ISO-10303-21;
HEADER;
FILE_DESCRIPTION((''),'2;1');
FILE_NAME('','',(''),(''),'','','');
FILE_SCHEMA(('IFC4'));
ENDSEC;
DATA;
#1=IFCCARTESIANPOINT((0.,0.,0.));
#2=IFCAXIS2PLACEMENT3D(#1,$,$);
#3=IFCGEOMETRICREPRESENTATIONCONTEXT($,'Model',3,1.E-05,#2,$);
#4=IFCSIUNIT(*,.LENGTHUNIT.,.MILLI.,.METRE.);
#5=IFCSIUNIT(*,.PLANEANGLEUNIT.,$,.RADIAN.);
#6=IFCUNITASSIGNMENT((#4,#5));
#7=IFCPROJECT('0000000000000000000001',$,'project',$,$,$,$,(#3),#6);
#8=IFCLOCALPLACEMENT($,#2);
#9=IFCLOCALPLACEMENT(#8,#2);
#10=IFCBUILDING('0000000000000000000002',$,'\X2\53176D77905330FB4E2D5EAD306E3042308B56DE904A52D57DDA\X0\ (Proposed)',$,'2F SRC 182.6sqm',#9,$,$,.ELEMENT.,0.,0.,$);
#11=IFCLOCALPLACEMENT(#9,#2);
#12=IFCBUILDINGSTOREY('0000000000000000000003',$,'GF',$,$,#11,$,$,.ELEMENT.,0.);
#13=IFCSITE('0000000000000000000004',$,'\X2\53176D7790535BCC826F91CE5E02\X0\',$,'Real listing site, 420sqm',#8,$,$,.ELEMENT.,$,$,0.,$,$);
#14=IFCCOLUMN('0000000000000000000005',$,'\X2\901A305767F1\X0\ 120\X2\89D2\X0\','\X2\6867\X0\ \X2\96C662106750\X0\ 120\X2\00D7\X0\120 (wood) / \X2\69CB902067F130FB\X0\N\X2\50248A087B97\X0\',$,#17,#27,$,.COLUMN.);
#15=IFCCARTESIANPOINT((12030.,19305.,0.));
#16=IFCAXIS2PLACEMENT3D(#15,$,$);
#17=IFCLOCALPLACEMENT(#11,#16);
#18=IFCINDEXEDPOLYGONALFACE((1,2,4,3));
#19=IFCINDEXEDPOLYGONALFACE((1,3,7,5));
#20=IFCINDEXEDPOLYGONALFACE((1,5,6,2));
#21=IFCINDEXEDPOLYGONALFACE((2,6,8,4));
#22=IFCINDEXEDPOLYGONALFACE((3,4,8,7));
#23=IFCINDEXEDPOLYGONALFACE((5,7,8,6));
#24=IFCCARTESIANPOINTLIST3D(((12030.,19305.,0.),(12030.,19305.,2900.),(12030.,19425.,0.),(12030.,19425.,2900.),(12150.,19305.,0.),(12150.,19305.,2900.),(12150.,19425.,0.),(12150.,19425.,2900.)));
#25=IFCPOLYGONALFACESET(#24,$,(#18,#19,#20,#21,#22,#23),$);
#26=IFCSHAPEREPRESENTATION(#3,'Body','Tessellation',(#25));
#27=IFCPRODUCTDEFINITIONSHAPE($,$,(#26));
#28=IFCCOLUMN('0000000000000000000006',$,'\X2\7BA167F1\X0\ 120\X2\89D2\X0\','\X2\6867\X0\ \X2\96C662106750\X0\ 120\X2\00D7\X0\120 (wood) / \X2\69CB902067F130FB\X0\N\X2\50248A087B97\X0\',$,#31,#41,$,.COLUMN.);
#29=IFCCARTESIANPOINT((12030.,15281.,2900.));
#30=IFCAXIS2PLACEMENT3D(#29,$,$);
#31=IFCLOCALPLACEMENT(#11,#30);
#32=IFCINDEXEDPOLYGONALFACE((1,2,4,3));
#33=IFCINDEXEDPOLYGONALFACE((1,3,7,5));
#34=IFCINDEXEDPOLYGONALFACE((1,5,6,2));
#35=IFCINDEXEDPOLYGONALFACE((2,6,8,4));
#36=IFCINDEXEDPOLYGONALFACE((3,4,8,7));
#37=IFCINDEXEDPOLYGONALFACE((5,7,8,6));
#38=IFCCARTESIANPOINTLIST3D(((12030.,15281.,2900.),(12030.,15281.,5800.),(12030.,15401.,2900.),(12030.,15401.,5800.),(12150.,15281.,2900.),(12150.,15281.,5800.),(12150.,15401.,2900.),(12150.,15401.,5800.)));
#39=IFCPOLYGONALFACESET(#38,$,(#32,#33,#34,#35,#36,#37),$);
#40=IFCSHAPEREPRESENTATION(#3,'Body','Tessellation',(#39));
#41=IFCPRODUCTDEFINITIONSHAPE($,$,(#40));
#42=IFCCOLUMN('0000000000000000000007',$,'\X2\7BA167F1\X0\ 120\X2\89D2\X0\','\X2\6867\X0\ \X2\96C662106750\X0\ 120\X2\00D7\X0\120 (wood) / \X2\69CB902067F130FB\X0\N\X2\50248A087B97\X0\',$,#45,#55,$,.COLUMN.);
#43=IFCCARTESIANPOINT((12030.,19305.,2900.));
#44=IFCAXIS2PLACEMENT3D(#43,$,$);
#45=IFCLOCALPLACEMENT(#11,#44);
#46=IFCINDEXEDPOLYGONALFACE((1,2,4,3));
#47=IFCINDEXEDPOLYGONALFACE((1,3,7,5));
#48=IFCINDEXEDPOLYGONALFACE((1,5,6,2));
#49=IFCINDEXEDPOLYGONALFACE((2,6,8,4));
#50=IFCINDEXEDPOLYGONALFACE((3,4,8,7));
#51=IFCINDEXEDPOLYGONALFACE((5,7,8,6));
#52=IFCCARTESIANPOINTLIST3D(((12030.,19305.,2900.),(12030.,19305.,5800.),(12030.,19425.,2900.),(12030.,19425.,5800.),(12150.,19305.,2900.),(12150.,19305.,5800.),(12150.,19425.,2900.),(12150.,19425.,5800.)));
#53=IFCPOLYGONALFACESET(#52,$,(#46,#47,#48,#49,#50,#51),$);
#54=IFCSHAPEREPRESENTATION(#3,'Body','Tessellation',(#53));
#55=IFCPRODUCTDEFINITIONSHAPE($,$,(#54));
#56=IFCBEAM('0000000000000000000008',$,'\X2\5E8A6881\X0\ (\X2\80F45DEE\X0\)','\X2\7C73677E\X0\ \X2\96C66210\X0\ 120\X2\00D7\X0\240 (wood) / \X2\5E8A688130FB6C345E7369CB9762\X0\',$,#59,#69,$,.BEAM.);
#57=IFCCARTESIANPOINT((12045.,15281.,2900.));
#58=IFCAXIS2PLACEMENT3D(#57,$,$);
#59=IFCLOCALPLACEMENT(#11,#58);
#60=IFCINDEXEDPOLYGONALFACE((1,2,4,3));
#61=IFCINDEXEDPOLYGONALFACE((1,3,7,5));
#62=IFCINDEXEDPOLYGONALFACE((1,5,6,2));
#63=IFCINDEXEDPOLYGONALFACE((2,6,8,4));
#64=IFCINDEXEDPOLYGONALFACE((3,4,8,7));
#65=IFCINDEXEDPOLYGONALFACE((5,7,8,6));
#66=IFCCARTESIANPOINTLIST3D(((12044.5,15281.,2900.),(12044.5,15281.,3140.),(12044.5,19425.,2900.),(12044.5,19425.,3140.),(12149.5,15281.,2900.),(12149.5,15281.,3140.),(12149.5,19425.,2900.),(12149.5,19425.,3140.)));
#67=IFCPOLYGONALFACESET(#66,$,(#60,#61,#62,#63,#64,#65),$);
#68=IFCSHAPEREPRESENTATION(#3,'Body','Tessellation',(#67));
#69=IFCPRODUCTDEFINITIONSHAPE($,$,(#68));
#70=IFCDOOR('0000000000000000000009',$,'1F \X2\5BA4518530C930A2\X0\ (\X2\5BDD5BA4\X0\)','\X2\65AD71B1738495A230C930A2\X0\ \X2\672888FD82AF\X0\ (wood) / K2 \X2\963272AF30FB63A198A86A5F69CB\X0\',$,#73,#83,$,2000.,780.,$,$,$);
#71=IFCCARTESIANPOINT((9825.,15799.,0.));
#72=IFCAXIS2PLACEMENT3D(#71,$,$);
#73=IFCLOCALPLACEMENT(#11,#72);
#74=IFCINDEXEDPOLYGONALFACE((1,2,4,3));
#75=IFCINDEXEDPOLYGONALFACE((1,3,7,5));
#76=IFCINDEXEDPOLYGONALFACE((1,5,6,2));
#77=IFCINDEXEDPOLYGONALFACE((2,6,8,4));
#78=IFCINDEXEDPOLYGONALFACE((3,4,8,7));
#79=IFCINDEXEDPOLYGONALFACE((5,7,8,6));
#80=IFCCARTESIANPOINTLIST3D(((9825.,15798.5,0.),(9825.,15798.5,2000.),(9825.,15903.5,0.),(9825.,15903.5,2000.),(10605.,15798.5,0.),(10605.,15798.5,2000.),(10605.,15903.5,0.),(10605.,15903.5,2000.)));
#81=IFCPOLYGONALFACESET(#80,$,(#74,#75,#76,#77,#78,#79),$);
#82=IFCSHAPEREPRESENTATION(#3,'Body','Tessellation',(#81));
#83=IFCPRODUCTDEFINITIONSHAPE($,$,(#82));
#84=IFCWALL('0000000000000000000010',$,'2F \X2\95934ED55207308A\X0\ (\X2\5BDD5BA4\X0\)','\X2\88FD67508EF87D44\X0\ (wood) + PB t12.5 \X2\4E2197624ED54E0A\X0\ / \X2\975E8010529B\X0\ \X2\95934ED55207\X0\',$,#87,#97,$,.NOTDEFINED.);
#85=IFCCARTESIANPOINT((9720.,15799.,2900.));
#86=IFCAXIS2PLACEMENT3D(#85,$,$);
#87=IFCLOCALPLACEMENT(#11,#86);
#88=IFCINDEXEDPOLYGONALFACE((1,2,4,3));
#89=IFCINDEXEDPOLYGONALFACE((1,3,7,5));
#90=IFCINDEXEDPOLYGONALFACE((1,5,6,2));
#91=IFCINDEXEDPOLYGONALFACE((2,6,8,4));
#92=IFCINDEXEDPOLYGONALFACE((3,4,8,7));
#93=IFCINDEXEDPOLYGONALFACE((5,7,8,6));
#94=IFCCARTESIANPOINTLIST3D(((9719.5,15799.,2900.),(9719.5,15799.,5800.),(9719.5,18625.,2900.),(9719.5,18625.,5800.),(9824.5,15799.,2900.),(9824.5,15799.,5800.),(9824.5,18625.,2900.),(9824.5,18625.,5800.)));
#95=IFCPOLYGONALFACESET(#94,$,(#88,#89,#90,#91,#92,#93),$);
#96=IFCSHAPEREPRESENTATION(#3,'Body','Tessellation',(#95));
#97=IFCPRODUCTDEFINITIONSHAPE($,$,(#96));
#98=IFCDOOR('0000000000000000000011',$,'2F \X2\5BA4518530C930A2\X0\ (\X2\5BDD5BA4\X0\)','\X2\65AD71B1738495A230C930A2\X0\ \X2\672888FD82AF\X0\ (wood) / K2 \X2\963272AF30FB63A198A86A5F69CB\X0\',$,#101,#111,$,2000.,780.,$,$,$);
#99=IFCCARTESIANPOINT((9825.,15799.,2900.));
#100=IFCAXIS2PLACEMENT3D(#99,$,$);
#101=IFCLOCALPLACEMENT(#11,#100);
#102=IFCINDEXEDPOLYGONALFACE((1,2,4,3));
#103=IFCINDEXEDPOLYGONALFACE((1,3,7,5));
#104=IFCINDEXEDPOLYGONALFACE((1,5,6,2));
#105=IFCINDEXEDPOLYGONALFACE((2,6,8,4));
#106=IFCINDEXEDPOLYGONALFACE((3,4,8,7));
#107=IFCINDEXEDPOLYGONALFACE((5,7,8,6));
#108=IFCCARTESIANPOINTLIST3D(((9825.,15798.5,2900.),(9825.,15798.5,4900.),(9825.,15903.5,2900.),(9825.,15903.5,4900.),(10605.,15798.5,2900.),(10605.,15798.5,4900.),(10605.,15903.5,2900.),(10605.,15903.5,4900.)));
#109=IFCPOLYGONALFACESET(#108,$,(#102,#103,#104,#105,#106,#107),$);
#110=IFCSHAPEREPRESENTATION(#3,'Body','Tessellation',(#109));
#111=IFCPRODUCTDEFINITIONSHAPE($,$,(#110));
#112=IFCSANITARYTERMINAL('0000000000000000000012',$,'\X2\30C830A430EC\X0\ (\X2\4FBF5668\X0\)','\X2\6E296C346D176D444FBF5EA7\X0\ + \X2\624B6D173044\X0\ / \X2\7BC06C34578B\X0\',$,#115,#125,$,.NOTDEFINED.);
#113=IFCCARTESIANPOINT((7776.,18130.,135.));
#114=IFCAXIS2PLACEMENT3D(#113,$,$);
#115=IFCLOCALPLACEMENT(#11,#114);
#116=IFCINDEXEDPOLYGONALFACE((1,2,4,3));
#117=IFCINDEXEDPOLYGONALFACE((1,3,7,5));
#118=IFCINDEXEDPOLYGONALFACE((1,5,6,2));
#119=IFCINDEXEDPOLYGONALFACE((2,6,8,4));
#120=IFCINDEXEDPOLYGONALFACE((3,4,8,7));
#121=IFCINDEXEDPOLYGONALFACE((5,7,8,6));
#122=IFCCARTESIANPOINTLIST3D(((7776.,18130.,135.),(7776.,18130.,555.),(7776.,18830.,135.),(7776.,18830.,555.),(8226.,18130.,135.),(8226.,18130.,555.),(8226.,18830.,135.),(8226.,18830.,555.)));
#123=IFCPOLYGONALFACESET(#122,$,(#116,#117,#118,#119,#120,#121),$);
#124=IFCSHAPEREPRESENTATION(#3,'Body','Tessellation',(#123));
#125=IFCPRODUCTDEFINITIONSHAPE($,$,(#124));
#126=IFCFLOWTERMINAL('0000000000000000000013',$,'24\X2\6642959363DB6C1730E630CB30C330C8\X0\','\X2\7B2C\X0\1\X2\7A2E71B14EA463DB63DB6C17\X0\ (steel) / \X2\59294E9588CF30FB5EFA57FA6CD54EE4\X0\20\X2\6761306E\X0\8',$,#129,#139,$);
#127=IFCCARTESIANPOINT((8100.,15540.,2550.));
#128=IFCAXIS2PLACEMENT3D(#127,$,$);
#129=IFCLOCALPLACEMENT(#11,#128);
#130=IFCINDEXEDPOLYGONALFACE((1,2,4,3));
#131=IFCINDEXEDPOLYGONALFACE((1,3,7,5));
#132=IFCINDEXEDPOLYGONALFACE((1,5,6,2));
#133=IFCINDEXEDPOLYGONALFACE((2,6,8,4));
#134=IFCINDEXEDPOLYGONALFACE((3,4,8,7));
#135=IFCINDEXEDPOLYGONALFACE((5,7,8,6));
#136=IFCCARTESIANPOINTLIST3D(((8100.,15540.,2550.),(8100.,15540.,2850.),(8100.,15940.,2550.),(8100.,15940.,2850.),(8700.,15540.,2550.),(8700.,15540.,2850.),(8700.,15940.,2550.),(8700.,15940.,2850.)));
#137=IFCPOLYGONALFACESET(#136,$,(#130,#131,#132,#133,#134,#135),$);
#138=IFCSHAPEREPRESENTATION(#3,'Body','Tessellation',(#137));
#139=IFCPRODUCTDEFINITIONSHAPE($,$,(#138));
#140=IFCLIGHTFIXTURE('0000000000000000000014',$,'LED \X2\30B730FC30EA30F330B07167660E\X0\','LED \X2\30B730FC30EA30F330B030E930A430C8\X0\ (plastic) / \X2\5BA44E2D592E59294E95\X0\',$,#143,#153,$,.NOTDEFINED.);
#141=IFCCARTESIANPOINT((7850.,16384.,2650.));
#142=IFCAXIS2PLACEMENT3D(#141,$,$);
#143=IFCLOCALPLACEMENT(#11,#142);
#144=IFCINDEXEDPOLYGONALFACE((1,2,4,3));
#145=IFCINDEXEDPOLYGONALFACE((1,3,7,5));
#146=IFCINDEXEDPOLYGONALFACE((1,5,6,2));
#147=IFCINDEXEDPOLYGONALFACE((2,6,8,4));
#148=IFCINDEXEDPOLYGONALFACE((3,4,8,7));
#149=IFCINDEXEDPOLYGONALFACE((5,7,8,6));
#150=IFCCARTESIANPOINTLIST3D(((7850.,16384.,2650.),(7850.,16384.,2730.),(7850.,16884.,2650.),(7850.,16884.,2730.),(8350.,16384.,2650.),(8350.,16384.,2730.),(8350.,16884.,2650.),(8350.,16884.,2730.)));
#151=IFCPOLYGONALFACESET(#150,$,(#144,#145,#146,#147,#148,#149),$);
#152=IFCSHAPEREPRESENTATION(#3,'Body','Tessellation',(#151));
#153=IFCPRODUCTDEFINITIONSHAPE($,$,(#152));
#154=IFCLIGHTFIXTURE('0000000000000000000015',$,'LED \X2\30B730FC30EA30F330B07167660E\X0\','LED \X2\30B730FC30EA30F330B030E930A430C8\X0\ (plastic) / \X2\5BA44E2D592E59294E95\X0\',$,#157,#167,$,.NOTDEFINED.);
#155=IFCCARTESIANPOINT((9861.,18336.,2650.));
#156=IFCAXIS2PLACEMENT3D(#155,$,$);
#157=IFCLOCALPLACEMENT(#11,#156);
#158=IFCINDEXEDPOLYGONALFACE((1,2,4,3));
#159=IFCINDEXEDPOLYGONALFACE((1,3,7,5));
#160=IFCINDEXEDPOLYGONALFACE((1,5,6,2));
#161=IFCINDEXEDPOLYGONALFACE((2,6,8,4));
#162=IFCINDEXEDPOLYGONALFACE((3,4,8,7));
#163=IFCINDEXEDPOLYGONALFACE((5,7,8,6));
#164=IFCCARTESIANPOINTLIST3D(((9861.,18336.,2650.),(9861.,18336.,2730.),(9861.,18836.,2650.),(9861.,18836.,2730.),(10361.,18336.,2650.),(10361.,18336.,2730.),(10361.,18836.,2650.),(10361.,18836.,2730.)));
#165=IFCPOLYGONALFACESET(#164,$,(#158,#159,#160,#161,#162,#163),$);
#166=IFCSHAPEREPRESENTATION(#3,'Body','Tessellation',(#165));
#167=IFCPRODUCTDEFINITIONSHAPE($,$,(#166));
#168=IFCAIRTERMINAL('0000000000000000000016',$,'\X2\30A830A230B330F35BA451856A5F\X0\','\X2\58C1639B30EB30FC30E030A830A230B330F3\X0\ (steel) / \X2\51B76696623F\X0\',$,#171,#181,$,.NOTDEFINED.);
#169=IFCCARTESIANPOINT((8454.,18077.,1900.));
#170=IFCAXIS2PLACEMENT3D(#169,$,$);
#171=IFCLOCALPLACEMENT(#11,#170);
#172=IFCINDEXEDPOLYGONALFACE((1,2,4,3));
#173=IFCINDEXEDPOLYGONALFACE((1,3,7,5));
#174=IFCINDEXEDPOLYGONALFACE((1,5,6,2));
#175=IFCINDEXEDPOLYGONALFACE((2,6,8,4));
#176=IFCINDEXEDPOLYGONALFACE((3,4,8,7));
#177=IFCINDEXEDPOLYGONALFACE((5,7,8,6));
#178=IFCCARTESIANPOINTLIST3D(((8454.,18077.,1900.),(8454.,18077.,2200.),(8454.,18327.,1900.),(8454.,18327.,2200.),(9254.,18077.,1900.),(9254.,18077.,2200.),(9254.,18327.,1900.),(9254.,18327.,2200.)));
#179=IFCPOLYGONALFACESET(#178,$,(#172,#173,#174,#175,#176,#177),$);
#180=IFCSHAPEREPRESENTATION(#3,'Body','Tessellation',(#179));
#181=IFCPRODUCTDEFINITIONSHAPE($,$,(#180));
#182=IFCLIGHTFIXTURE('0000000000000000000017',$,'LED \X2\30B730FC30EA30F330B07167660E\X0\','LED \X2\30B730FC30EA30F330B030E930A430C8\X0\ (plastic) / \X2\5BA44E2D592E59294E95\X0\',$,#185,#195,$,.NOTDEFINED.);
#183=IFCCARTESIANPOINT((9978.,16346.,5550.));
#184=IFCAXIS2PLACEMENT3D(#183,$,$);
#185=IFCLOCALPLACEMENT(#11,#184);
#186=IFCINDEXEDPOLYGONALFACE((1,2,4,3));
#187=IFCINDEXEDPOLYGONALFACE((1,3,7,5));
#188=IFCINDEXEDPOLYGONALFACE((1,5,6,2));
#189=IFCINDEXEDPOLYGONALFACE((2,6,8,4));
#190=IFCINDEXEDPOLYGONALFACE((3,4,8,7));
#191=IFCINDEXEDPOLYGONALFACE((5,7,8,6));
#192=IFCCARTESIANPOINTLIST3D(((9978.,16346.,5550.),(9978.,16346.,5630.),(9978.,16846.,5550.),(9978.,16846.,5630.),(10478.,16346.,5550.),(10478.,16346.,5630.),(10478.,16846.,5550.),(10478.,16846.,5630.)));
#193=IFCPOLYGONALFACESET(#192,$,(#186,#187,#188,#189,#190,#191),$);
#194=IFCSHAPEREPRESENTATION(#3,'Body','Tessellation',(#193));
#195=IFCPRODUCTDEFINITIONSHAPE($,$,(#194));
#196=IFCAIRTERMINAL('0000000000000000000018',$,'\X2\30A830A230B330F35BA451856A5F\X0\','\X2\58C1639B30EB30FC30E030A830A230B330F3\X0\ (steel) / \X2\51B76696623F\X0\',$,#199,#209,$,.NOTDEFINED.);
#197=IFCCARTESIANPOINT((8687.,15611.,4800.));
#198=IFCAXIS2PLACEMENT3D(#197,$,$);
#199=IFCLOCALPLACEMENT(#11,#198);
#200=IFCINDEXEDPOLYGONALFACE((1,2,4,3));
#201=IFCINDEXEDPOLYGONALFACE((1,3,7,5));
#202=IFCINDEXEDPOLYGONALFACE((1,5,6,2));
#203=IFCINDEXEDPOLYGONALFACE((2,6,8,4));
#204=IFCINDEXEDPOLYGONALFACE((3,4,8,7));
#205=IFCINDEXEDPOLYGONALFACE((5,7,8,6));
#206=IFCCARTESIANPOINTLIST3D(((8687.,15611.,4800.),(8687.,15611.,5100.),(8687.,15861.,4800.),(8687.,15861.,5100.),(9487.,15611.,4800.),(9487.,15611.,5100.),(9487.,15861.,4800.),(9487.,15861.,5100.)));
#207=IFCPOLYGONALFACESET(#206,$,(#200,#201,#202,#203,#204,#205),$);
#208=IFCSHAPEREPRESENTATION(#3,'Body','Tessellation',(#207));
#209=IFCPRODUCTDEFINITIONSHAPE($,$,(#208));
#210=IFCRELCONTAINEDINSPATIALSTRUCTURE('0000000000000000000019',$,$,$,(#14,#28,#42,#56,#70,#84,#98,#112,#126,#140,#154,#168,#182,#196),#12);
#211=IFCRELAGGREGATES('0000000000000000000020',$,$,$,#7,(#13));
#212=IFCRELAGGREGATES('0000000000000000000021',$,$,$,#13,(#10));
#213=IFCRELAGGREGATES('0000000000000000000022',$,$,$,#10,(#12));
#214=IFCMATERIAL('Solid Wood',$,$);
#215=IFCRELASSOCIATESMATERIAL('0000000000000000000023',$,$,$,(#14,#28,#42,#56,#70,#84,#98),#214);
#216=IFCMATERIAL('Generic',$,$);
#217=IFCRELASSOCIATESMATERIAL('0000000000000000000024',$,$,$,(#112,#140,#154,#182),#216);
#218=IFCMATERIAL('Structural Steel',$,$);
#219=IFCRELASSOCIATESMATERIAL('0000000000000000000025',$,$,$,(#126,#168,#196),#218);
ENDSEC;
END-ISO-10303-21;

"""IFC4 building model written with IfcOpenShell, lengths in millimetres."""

from ifc_helpers import new_model, si_unit, frame, frame_2d, origin, place, context, project, spatial, rectangle, extrude, material, element, save


model = new_model("IFC4")

# Units and contexts
model_context = context("Model", 3, precision=1e-05, world=origin())
ifc_project = project(units=[si_unit("LENGTHUNIT", "METRE", prefix="MILLI"), si_unit("PLANEANGLEUNIT", "RADIAN")], contexts=[model_context])

# Site, building, storey
site_placement = place(None, origin())
site = spatial("IfcSite", under=ifc_project, at=site_placement, Name="北海道富良野市", ObjectType="Real listing site, 420sqm", CompositionType="ELEMENT", RefElevation=0.0)
building_placement = place(site_placement, origin())
building = spatial("IfcBuilding", under=site, at=building_placement, Name="北海道・中庭のある回遊動線 (Proposed)", ObjectType="2F SRC 182.6sqm", CompositionType="ELEMENT", ElevationOfRefHeight=0.0, ElevationOfTerrain=0.0)
storey_placement = place(building_placement, origin())
storey = spatial("IfcBuildingStorey", under=building, at=storey_placement, Name="GF", CompositionType="ELEMENT", Elevation=0.0)

# Columns
ifc_material_1 = material(Name="Solid Wood")
column_1_placement = place(storey_placement, frame((12030.0, 19305.0, 0.0)))
element("IfcColumn", 1, at=column_1_placement, inside=storey, material=ifc_material_1, Name="通し柱 120角", Description="桧 集成材 120×120 (wood) / 構造柱・N値計算", PredefinedType="COLUMN", context=model_context, shape_type="SweptSolid", body=[
    extrude(rectangle(XDim=120.0, YDim=120.0, at=frame_2d((60.0, 60.0))), frame((12030.0, 19305.0, 0.0)), (0.0, 0.0, 1.0), 2900.0),
])
column_2_placement = place(storey_placement, frame((12030.0, 15281.0, 2900.0)))
element("IfcColumn", 2, at=column_2_placement, inside=storey, material=ifc_material_1, Name="管柱 120角", Description="桧 集成材 120×120 (wood) / 構造柱・N値計算", PredefinedType="COLUMN", context=model_context, shape_type="SweptSolid", body=[
    extrude(rectangle(XDim=120.0, YDim=120.0, at=frame_2d((60.0, 60.0))), frame((12030.0, 15281.0, 2900.0)), (0.0, 0.0, 1.0), 2900.0),
])
column_3_placement = place(storey_placement, frame((12030.0, 19305.0, 2900.0)))
element("IfcColumn", 3, at=column_3_placement, inside=storey, material=ifc_material_1, Name="管柱 120角", Description="桧 集成材 120×120 (wood) / 構造柱・N値計算", PredefinedType="COLUMN", context=model_context, shape_type="SweptSolid", body=[
    extrude(rectangle(XDim=120.0, YDim=120.0, at=frame_2d((60.0, 60.0))), frame((12030.0, 19305.0, 2900.0)), (0.0, 0.0, 1.0), 2900.0),
])

# Beam
beam_1_placement = place(storey_placement, frame((12045.0, 15281.0, 2900.0)))
element("IfcBeam", 4, at=beam_1_placement, inside=storey, material=ifc_material_1, Name="床梁 (胴差)", Description="米松 集成 120×240 (wood) / 床梁・水平構面", PredefinedType="BEAM", context=model_context, shape_type="SweptSolid", body=[
    extrude(rectangle(XDim=105.0, YDim=4144.0, at=frame_2d((52.0, 2072.0))), frame((12045.0, 15281.0, 2900.0)), (0.0, 0.0, 1.0), 240.0),
])

# Door
door_1_placement = place(storey_placement, frame((9825.0, 15799.0, 0.0)))
element("IfcDoor", 5, at=door_1_placement, inside=storey, material=ifc_material_1, Name="1F 室内ドア (寝室)", Description="断熱玄関ドア 木製芯 (wood) / K2 防犯・採風機構", OverallHeight=2000.0, OverallWidth=780.0, context=model_context, shape_type="SweptSolid", body=[
    extrude(rectangle(XDim=780.0, YDim=105.0, at=frame_2d((390.0, 52.0))), frame((9825.0, 15799.0, 0.0)), (0.0, 0.0, 1.0), 2000.0),
])

# Wall
wall_1_placement = place(storey_placement, frame((9720.0, 15799.0, 2900.0)))
element("IfcWall", 6, at=wall_1_placement, inside=storey, material=ifc_material_1, Name="2F 間仕切り (寝室)", Description="製材軸組 (wood) + PB t12.5 両面仕上 / 非耐力 間仕切", PredefinedType="NOTDEFINED", context=model_context, shape_type="SweptSolid", body=[
    extrude(rectangle(XDim=105.0, YDim=2826.0, at=frame_2d((52.0, 1413.0))), frame((9720.0, 15799.0, 2900.0)), (0.0, 0.0, 1.0), 2900.0),
])

# Door
door_2_placement = place(storey_placement, frame((9825.0, 15799.0, 2900.0)))
element("IfcDoor", 7, at=door_2_placement, inside=storey, material=ifc_material_1, Name="2F 室内ドア (寝室)", Description="断熱玄関ドア 木製芯 (wood) / K2 防犯・採風機構", OverallHeight=2000.0, OverallWidth=780.0, context=model_context, shape_type="SweptSolid", body=[
    extrude(rectangle(XDim=780.0, YDim=105.0, at=frame_2d((390.0, 52.0))), frame((9825.0, 15799.0, 2900.0)), (0.0, 0.0, 1.0), 2000.0),
])

# Sanitary terminal
ifc_material_2 = material(Name="Generic")
sanitary_terminal_placement = place(storey_placement, frame((7776.0, 18130.0, 135.0)))
element("IfcSanitaryTerminal", 8, at=sanitary_terminal_placement, inside=storey, material=ifc_material_2, Name="トイレ (便器)", Description="温水洗浄便座 + 手洗い / 節水型", PredefinedType="NOTDEFINED", context=model_context, shape_type="SweptSolid", body=[
    extrude(rectangle(XDim=450.0, YDim=700.0, at=frame_2d((225.0, 350.0))), frame((7776.0, 18130.0, 135.0)), (0.0, 0.0, 1.0), 420.0),
])

# Flow terminal
ifc_material_3 = material(Name="Structural Steel")
flow_terminal_placement = place(storey_placement, frame((8100.0, 15540.0, 2550.0)))
element("IfcFlowTerminal", 9, at=flow_terminal_placement, inside=storey, material=ifc_material_3, Name="24時間換気ユニット", Description="第1種熱交換換気 (steel) / 天井裏・建基法令20条の8", context=model_context, shape_type="SweptSolid", body=[
    extrude(rectangle(XDim=600.0, YDim=400.0, at=frame_2d((300.0, 200.0))), frame((8100.0, 15540.0, 2550.0)), (0.0, 0.0, 1.0), 300.0),
])

# Light fixtures
light_fixture_1_placement = place(storey_placement, frame((7850.0, 16384.0, 2650.0)))
element("IfcLightFixture", 10, at=light_fixture_1_placement, inside=storey, material=ifc_material_2, Name="LED シーリング照明", Description="LED シーリングライト (plastic) / 室中央天井", PredefinedType="NOTDEFINED", context=model_context, shape_type="SweptSolid", body=[
    extrude(rectangle(XDim=500.0, YDim=500.0, at=frame_2d((250.0, 250.0))), frame((7850.0, 16384.0, 2650.0)), (0.0, 0.0, 1.0), 80.0),
])
light_fixture_2_placement = place(storey_placement, frame((9861.0, 18336.0, 2650.0)))
element("IfcLightFixture", 11, at=light_fixture_2_placement, inside=storey, material=ifc_material_2, Name="LED シーリング照明", Description="LED シーリングライト (plastic) / 室中央天井", PredefinedType="NOTDEFINED", context=model_context, shape_type="SweptSolid", body=[
    extrude(rectangle(XDim=500.0, YDim=500.0, at=frame_2d((250.0, 250.0))), frame((9861.0, 18336.0, 2650.0)), (0.0, 0.0, 1.0), 80.0),
])

# Air terminal
air_terminal_1_placement = place(storey_placement, frame((8454.0, 18077.0, 1900.0)))
element("IfcAirTerminal", 12, at=air_terminal_1_placement, inside=storey, material=ifc_material_3, Name="エアコン室内機", Description="壁掛ルームエアコン (steel) / 冷暖房", PredefinedType="NOTDEFINED", context=model_context, shape_type="SweptSolid", body=[
    extrude(rectangle(XDim=800.0, YDim=250.0, at=frame_2d((400.0, 125.0))), frame((8454.0, 18077.0, 1900.0)), (0.0, 0.0, 1.0), 300.0),
])

# Light fixture
light_fixture_3_placement = place(storey_placement, frame((9978.0, 16346.0, 5550.0)))
element("IfcLightFixture", 13, at=light_fixture_3_placement, inside=storey, material=ifc_material_2, Name="LED シーリング照明", Description="LED シーリングライト (plastic) / 室中央天井", PredefinedType="NOTDEFINED", context=model_context, shape_type="SweptSolid", body=[
    extrude(rectangle(XDim=500.0, YDim=500.0, at=frame_2d((250.0, 250.0))), frame((9978.0, 16346.0, 5550.0)), (0.0, 0.0, 1.0), 80.0),
])

# Air terminal
air_terminal_2_placement = place(storey_placement, frame((8687.0, 15611.0, 4800.0)))
element("IfcAirTerminal", 14, at=air_terminal_2_placement, inside=storey, material=ifc_material_3, Name="エアコン室内機", Description="壁掛ルームエアコン (steel) / 冷暖房", PredefinedType="NOTDEFINED", context=model_context, shape_type="SweptSolid", body=[
    extrude(rectangle(XDim=800.0, YDim=250.0, at=frame_2d((400.0, 125.0))), frame((8687.0, 15611.0, 4800.0)), (0.0, 0.0, 1.0), 300.0),
])

save(model, "model.ifc")
